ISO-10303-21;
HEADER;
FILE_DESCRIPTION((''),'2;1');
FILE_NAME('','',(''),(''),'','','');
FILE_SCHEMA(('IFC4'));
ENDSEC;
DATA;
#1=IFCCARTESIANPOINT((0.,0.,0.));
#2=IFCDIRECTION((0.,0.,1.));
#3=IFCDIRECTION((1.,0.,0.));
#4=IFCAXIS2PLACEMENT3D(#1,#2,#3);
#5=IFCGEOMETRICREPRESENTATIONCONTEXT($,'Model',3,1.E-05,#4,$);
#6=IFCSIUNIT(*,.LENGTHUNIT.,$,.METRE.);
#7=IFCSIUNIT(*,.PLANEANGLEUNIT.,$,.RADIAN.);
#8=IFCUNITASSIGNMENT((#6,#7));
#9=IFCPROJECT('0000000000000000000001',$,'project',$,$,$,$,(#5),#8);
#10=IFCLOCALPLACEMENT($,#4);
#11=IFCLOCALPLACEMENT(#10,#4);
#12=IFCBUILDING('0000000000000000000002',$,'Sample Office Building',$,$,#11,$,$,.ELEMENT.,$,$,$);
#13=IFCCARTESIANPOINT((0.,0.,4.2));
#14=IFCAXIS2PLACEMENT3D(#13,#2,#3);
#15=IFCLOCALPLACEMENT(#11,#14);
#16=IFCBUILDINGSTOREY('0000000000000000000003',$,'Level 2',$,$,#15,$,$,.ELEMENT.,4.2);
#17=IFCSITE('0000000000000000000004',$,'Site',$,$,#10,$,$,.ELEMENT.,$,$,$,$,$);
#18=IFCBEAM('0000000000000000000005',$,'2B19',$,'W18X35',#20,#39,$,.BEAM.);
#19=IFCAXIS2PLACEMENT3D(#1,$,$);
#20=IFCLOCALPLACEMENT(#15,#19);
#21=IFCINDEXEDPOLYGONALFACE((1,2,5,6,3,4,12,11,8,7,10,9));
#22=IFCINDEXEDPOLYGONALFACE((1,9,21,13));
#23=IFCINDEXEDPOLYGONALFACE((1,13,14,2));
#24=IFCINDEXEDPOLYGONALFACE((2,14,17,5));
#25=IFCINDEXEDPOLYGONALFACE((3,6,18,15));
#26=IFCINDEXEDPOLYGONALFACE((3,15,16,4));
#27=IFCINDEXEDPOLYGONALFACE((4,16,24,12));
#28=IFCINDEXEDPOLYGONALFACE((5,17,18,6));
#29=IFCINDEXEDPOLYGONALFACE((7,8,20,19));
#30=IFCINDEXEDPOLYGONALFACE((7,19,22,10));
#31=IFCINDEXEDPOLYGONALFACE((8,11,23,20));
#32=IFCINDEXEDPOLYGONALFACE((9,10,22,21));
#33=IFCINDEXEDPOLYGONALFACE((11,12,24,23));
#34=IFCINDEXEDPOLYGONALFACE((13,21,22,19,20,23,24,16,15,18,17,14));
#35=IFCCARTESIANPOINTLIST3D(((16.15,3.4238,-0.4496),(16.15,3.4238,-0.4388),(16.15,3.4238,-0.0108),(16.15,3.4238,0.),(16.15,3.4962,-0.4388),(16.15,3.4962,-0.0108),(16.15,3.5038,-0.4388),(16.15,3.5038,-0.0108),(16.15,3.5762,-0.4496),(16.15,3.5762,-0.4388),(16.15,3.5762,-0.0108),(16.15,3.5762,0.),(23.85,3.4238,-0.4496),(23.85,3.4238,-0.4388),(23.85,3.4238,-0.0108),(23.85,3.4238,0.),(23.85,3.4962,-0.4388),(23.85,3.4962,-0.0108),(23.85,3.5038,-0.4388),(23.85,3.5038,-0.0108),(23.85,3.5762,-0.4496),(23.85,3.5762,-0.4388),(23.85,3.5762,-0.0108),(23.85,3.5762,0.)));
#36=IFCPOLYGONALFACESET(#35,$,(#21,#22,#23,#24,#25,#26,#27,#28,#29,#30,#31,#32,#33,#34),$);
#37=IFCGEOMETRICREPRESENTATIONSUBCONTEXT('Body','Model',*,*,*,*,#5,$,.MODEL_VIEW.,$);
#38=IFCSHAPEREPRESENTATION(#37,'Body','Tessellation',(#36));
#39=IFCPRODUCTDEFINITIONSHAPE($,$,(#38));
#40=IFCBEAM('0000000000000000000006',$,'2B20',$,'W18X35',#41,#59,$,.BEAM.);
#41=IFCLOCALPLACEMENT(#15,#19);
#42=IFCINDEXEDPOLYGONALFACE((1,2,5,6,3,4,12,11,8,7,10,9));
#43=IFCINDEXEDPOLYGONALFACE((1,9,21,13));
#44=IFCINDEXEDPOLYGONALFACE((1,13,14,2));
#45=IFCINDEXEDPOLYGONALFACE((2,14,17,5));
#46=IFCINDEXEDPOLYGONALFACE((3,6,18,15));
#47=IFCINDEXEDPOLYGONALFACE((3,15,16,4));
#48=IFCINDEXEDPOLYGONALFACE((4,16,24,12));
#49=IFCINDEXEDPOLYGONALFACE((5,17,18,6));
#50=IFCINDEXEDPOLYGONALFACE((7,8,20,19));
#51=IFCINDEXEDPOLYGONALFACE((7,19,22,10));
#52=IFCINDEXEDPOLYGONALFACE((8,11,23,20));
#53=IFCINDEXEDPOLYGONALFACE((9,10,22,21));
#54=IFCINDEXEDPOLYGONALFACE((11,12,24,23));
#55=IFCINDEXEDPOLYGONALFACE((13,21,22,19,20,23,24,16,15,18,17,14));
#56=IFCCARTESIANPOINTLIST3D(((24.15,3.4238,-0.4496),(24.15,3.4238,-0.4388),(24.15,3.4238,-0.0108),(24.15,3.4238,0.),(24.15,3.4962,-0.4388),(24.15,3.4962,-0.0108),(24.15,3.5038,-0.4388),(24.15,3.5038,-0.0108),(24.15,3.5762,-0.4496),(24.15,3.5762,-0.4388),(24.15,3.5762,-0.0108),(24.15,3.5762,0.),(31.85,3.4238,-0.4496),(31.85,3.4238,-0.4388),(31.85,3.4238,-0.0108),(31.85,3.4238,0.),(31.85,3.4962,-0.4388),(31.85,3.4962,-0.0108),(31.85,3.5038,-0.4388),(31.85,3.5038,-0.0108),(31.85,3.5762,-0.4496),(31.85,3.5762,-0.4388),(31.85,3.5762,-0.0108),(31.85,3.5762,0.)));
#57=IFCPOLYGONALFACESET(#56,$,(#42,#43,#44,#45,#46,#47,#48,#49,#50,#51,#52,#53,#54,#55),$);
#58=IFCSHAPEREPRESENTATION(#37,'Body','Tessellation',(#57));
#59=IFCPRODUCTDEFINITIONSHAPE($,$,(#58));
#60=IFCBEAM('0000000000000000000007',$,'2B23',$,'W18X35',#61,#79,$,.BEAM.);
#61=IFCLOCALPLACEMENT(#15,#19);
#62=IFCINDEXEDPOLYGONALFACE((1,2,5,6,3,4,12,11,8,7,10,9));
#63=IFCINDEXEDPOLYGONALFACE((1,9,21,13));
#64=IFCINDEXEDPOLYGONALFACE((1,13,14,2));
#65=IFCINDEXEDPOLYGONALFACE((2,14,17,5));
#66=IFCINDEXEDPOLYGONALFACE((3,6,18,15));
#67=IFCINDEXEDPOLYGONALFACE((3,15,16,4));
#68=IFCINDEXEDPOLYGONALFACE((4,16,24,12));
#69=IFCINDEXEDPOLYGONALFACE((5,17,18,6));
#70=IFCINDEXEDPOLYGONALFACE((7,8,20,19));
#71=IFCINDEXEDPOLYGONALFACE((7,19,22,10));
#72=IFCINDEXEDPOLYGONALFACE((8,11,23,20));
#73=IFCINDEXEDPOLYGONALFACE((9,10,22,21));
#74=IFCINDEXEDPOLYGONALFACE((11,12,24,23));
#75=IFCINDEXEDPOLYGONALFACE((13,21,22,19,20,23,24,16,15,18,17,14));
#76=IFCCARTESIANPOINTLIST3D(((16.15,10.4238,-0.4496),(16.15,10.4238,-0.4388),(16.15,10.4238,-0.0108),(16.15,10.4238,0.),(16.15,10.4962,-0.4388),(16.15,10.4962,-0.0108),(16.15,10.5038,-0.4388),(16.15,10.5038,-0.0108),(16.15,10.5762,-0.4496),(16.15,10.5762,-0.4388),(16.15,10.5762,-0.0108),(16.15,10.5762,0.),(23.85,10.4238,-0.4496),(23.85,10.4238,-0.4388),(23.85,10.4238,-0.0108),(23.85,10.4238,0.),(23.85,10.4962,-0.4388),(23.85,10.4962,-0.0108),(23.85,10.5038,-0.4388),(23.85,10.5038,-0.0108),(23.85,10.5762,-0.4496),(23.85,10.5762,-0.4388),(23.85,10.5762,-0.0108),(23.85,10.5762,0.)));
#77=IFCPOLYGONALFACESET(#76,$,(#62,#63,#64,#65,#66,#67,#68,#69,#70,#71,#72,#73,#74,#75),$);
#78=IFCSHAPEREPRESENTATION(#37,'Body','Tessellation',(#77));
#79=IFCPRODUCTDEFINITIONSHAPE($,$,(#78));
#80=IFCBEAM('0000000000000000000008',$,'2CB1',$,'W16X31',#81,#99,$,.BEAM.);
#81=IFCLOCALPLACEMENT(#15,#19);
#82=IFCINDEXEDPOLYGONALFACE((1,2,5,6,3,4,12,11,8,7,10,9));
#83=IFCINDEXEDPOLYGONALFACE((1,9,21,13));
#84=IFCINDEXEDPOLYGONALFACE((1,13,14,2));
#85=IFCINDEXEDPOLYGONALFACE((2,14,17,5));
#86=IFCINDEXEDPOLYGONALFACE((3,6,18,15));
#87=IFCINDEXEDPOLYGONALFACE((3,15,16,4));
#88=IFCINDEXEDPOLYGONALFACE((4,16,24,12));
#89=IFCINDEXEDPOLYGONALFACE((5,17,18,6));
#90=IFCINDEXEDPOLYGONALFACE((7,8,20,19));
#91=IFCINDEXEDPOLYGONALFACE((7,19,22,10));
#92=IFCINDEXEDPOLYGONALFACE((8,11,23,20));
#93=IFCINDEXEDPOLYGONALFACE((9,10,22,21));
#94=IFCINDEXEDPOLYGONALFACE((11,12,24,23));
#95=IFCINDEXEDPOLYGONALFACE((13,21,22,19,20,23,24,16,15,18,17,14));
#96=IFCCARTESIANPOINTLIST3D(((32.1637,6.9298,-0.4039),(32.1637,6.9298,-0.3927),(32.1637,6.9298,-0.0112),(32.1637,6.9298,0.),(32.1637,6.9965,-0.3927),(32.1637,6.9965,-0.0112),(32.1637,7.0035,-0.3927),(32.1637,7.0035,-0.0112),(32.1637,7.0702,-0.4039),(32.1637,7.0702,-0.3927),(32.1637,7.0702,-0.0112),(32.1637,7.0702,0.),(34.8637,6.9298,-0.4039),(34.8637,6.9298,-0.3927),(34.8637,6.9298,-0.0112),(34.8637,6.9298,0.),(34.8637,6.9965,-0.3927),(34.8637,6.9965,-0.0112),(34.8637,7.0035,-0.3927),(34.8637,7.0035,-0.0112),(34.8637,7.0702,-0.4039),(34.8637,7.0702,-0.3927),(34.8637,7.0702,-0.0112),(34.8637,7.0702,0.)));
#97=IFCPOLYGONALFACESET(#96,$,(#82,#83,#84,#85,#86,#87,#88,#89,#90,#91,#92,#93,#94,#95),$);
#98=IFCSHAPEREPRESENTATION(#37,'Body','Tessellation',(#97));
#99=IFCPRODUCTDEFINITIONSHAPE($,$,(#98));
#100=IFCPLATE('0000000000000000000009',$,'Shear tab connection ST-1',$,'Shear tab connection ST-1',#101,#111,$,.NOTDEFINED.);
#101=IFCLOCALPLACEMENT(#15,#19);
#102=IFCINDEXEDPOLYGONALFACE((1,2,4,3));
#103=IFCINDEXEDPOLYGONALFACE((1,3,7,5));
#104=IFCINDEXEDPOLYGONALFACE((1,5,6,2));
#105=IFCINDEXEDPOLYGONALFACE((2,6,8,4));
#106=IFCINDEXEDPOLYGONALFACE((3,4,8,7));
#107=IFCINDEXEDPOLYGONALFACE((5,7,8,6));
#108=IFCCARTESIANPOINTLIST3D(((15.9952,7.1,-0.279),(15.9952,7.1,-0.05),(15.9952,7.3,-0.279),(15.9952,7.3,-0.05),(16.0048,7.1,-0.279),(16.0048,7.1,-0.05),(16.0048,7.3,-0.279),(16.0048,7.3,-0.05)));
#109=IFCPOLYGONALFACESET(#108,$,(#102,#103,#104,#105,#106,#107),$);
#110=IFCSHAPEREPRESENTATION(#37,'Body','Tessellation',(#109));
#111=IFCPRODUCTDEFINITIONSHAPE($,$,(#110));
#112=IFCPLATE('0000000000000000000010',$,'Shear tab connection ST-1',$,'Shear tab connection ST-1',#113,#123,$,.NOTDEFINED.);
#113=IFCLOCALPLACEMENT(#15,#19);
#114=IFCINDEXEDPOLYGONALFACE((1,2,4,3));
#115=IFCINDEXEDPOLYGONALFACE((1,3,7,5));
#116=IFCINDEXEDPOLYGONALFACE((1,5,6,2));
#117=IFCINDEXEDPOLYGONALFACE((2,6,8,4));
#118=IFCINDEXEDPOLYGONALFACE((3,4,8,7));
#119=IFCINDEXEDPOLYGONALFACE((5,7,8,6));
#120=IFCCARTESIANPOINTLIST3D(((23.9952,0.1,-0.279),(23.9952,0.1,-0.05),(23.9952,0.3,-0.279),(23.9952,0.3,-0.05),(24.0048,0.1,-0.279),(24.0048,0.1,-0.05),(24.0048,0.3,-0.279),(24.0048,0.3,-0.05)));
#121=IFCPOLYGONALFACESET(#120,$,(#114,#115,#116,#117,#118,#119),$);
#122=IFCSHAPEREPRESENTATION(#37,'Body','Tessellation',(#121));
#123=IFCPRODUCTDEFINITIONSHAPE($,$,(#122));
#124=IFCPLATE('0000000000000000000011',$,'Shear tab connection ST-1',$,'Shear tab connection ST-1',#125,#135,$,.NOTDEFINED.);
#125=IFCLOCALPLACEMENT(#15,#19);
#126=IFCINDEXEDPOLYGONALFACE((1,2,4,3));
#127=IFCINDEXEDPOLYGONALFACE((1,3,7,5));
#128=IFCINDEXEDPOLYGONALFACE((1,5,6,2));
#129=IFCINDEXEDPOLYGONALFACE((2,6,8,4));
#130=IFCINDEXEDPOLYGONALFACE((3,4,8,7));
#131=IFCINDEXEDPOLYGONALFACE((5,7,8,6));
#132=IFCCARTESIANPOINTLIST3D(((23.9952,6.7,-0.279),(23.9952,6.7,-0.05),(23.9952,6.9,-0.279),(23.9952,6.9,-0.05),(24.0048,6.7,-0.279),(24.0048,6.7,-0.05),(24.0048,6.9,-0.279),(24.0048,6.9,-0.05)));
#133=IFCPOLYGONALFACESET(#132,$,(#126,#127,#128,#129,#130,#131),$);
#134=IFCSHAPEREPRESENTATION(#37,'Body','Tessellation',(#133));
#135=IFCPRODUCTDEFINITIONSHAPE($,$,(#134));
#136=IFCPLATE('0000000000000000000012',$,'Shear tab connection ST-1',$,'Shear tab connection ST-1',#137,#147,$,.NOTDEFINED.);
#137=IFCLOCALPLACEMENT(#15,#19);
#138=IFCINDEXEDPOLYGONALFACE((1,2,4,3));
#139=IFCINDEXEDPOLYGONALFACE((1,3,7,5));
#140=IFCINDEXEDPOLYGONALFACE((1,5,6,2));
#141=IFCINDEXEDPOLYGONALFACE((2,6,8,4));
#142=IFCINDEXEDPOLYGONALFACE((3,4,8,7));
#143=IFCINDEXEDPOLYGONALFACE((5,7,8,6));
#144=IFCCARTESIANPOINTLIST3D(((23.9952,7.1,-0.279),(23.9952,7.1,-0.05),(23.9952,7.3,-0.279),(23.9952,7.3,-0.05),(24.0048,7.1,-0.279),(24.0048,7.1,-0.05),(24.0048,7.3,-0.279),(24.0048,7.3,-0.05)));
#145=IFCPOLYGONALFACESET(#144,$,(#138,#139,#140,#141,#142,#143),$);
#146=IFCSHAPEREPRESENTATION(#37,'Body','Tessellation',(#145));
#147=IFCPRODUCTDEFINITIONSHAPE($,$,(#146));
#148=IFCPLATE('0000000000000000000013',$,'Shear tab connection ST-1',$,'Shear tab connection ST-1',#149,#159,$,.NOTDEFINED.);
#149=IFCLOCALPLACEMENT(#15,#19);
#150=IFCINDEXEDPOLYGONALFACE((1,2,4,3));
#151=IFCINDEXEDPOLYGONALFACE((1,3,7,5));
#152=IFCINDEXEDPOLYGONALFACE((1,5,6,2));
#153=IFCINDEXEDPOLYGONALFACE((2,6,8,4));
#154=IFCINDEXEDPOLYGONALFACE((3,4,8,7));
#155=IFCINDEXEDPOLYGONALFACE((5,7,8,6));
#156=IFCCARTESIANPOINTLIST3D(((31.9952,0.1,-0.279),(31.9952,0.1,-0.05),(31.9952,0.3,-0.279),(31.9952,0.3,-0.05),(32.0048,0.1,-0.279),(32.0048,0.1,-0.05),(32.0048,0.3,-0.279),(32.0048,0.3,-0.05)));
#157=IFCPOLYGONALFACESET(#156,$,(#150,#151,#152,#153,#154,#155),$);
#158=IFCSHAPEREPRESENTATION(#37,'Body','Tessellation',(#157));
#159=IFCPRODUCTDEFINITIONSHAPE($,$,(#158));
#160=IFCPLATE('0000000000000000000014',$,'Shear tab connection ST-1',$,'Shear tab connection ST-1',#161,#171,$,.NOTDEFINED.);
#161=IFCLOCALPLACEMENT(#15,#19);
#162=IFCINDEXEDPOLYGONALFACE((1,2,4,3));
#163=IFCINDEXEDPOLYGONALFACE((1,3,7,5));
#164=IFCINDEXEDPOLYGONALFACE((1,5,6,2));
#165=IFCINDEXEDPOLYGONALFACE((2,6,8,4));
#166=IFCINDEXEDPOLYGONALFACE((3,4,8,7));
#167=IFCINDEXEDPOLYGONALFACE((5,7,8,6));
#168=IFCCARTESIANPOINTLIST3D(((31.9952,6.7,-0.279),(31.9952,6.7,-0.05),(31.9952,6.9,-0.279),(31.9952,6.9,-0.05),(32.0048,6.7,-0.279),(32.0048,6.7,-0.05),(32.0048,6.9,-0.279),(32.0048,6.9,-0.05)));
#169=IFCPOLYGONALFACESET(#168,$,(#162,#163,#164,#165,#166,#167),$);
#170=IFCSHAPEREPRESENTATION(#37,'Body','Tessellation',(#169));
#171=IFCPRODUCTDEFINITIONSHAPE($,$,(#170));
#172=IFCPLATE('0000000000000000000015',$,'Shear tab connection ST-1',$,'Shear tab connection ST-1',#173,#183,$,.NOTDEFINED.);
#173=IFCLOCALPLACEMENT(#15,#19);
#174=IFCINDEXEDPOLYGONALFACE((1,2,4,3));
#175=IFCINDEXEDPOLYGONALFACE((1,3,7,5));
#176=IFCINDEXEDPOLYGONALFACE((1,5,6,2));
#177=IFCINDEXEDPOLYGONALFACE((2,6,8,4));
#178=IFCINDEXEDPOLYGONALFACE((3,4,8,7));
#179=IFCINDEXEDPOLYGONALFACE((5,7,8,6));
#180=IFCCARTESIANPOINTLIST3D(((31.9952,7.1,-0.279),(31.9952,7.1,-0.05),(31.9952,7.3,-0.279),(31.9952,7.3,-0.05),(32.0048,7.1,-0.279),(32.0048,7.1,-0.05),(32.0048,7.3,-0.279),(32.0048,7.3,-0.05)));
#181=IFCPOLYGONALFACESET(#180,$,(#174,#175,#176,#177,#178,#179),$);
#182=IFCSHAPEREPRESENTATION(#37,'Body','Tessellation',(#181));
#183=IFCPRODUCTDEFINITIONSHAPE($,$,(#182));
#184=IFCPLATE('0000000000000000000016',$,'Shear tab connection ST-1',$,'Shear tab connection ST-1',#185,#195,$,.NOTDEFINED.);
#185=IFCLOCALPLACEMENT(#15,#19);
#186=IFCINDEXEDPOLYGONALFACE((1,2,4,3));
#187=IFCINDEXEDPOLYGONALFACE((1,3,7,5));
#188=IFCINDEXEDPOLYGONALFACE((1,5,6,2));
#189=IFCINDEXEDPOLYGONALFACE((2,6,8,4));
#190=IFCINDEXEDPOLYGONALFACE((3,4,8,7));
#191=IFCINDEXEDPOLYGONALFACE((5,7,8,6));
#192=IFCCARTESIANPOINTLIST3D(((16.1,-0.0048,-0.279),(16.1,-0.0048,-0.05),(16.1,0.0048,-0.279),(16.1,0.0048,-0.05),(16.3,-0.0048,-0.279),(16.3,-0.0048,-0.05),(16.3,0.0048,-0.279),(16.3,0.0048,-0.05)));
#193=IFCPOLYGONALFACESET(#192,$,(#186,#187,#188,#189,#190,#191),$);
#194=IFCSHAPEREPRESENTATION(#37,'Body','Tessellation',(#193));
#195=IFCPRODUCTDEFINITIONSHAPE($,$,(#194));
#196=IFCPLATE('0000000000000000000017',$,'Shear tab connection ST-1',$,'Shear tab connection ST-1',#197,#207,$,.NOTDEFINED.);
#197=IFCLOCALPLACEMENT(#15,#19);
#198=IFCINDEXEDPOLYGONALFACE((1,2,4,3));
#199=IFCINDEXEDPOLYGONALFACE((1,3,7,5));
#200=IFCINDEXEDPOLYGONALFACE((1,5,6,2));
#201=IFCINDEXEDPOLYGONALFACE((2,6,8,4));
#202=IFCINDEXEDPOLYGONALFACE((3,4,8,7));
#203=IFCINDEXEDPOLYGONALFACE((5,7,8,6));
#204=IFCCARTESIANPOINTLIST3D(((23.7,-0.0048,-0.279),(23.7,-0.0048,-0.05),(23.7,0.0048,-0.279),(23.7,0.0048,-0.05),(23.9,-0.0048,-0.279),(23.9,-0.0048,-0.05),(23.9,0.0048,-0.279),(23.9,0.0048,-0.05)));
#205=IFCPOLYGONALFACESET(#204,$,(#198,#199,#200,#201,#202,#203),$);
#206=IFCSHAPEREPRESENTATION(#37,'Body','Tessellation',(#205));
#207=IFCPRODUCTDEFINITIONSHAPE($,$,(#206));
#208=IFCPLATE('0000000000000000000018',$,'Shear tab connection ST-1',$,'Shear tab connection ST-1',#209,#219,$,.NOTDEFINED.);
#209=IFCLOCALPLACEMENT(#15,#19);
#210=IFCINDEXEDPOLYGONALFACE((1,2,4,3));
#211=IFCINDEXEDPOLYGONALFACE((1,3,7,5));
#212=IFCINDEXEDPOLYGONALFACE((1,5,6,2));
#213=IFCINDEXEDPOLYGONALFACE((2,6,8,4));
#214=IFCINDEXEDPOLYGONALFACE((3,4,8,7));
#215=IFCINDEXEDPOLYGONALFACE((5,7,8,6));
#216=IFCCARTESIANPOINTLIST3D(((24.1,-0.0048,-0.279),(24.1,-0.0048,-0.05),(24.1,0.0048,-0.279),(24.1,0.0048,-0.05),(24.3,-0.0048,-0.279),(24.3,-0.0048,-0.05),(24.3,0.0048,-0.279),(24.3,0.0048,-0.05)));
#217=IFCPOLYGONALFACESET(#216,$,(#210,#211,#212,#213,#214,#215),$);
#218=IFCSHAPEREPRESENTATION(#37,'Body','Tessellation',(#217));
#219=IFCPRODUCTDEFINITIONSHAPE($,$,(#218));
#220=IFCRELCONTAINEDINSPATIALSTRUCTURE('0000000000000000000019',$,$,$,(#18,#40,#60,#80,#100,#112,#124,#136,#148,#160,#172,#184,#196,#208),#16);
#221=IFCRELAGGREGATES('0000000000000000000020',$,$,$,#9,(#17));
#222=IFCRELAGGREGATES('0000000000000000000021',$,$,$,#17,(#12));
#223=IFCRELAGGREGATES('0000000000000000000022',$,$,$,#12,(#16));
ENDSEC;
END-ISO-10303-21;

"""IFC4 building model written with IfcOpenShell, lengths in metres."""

from ifc_helpers import new_model, si_unit, frame, origin_with_axes, place, context, subcontext, project, spatial, rectangle, i_section, extrude, element, save


model = new_model("IFC4")

# Units and contexts
model_context = context("Model", 3, precision=1e-05, world=origin_with_axes())
body_context = subcontext(model_context, "Body", "Model", "MODEL_VIEW")
ifc_project = project(units=[si_unit("LENGTHUNIT", "METRE"), si_unit("PLANEANGLEUNIT", "RADIAN")], contexts=[model_context])

# Site, building, storey
site_placement = place(None, origin_with_axes())
site = spatial("IfcSite", under=ifc_project, at=site_placement, Name="Site", CompositionType="ELEMENT")
building_placement = place(site_placement, origin_with_axes())
building = spatial("IfcBuilding", under=site, at=building_placement, Name="Sample Office Building", CompositionType="ELEMENT")
storey_placement = place(building_placement, frame((0.0, 0.0, 4.2), z_axis=(0.0, 0.0, 1.0), x_axis=(1.0, 0.0, 0.0)))
storey = spatial("IfcBuildingStorey", under=building, at=storey_placement, Name="Level 2", CompositionType="ELEMENT", Elevation=4.2)

# Beams
for number, where, z_axis, x_axis, name in (
    (1, (16.15, 3.5, 3.9752), (1.0, 0.0, 0.0), (0.0, 1.0, 0.0), "2B19"),
    (2, (24.15, 3.5, 3.9752), (1.0, 0.0, 0.0), (0.0, 1.0, 0.0), "2B20"),
    (3, (16.15, 10.5, 3.9752), (1.0, 0.0, 0.0), (0.0, 1.0, 0.0), "2B23"),
):
    element("IfcBeam", number, at=place(None, frame(where, z_axis=z_axis, x_axis=x_axis)), inside=storey, Name=name, ObjectType="W18X35", PredefinedType="BEAM", context=body_context, shape_type="SweptSolid", body=[
        extrude(i_section(OverallWidth=0.1524, OverallDepth=0.4496, WebThickness=0.0076, FlangeThickness=0.0108), None, (0.0, 0.0, 1.0), 7.7),
    ])
beam_1_placement = place(None, frame((32.1637, 7.0, 3.9981), z_axis=(1.0, 0.0, 0.0), x_axis=(0.0, 1.0, 0.0)))
element("IfcBeam", 4, at=beam_1_placement, inside=storey, Name="2CB1", ObjectType="W16X31", PredefinedType="BEAM", context=body_context, shape_type="SweptSolid", body=[
    extrude(i_section(OverallWidth=0.1405, OverallDepth=0.4039, WebThickness=0.007, FlangeThickness=0.0112), None, (0.0, 0.0, 1.0), 2.7),
])

# Plates
plate_1_placement = place(None, frame((16.0, 7.2, 3.921), z_axis=(0.0, 0.0, 1.0), x_axis=(1.0, 0.0, 0.0)))
element("IfcPlate", 5, at=plate_1_placement, inside=storey, Name="Shear tab connection ST-1", ObjectType="Shear tab connection ST-1", PredefinedType="NOTDEFINED", context=body_context, shape_type="SweptSolid", body=[
    extrude(rectangle(XDim=0.0095, YDim=0.2), None, (0.0, 0.0, 1.0), 0.229),
])
plate_2_placement = place(None, frame((24.0, 0.2, 3.921), z_axis=(0.0, 0.0, 1.0), x_axis=(1.0, 0.0, 0.0)))
element("IfcPlate", 6, at=plate_2_placement, inside=storey, Name="Shear tab connection ST-1", ObjectType="Shear tab connection ST-1", PredefinedType="NOTDEFINED", context=body_context, shape_type="SweptSolid", body=[
    extrude(rectangle(XDim=0.0095, YDim=0.2), None, (0.0, 0.0, 1.0), 0.229),
])
for number, where, z_axis, x_axis, name in (
    (7, (24.0, 6.8, 3.921), (0.0, 0.0, 1.0), (1.0, 0.0, 0.0), "Shear tab connection ST-1"),
    (8, (24.0, 7.2, 3.921), (0.0, 0.0, 1.0), (1.0, 0.0, 0.0), "Shear tab connection ST-1"),
):
    element("IfcPlate", number, at=place(None, frame(where, z_axis=z_axis, x_axis=x_axis)), inside=storey, Name=name, ObjectType="Shear tab connection ST-1", PredefinedType="NOTDEFINED", context=body_context, shape_type="SweptSolid", body=[
        extrude(rectangle(XDim=0.0095, YDim=0.2), None, (0.0, 0.0, 1.0), 0.229),
    ])
plate_3_placement = place(None, frame((32.0, 0.2, 3.921), z_axis=(0.0, 0.0, 1.0), x_axis=(1.0, 0.0, 0.0)))
element("IfcPlate", 9, at=plate_3_placement, inside=storey, Name="Shear tab connection ST-1", ObjectType="Shear tab connection ST-1", PredefinedType="NOTDEFINED", context=body_context, shape_type="SweptSolid", body=[
    extrude(rectangle(XDim=0.0095, YDim=0.2), None, (0.0, 0.0, 1.0), 0.229),
])
for number, where, z_axis, x_axis, name in (
    (10, (32.0, 6.8, 3.921), (0.0, 0.0, 1.0), (1.0, 0.0, 0.0), "Shear tab connection ST-1"),
    (11, (32.0, 7.2, 3.921), (0.0, 0.0, 1.0), (1.0, 0.0, 0.0), "Shear tab connection ST-1"),
):
    element("IfcPlate", number, at=place(None, frame(where, z_axis=z_axis, x_axis=x_axis)), inside=storey, Name=name, ObjectType="Shear tab connection ST-1", PredefinedType="NOTDEFINED", context=body_context, shape_type="SweptSolid", body=[
        extrude(rectangle(XDim=0.0095, YDim=0.2), None, (0.0, 0.0, 1.0), 0.229),
    ])
for number, where, z_axis, x_axis, name in (
    (12, (16.2, 0.0, 3.921), (0.0, 0.0, 1.0), (1.0, 0.0, 0.0), "Shear tab connection ST-1"),
    (13, (23.8, 0.0, 3.921), (0.0, 0.0, 1.0), (1.0, 0.0, 0.0), "Shear tab connection ST-1"),
    (14, (24.2, 0.0, 3.921), (0.0, 0.0, 1.0), (1.0, 0.0, 0.0), "Shear tab connection ST-1"),
):
    element("IfcPlate", number, at=place(None, frame(where, z_axis=z_axis, x_axis=x_axis)), inside=storey, Name=name, ObjectType="Shear tab connection ST-1", PredefinedType="NOTDEFINED", context=body_context, shape_type="SweptSolid", body=[
        extrude(rectangle(XDim=0.2, YDim=0.0095), None, (0.0, 0.0, 1.0), 0.229),
    ])

save(model, "model.ifc")
